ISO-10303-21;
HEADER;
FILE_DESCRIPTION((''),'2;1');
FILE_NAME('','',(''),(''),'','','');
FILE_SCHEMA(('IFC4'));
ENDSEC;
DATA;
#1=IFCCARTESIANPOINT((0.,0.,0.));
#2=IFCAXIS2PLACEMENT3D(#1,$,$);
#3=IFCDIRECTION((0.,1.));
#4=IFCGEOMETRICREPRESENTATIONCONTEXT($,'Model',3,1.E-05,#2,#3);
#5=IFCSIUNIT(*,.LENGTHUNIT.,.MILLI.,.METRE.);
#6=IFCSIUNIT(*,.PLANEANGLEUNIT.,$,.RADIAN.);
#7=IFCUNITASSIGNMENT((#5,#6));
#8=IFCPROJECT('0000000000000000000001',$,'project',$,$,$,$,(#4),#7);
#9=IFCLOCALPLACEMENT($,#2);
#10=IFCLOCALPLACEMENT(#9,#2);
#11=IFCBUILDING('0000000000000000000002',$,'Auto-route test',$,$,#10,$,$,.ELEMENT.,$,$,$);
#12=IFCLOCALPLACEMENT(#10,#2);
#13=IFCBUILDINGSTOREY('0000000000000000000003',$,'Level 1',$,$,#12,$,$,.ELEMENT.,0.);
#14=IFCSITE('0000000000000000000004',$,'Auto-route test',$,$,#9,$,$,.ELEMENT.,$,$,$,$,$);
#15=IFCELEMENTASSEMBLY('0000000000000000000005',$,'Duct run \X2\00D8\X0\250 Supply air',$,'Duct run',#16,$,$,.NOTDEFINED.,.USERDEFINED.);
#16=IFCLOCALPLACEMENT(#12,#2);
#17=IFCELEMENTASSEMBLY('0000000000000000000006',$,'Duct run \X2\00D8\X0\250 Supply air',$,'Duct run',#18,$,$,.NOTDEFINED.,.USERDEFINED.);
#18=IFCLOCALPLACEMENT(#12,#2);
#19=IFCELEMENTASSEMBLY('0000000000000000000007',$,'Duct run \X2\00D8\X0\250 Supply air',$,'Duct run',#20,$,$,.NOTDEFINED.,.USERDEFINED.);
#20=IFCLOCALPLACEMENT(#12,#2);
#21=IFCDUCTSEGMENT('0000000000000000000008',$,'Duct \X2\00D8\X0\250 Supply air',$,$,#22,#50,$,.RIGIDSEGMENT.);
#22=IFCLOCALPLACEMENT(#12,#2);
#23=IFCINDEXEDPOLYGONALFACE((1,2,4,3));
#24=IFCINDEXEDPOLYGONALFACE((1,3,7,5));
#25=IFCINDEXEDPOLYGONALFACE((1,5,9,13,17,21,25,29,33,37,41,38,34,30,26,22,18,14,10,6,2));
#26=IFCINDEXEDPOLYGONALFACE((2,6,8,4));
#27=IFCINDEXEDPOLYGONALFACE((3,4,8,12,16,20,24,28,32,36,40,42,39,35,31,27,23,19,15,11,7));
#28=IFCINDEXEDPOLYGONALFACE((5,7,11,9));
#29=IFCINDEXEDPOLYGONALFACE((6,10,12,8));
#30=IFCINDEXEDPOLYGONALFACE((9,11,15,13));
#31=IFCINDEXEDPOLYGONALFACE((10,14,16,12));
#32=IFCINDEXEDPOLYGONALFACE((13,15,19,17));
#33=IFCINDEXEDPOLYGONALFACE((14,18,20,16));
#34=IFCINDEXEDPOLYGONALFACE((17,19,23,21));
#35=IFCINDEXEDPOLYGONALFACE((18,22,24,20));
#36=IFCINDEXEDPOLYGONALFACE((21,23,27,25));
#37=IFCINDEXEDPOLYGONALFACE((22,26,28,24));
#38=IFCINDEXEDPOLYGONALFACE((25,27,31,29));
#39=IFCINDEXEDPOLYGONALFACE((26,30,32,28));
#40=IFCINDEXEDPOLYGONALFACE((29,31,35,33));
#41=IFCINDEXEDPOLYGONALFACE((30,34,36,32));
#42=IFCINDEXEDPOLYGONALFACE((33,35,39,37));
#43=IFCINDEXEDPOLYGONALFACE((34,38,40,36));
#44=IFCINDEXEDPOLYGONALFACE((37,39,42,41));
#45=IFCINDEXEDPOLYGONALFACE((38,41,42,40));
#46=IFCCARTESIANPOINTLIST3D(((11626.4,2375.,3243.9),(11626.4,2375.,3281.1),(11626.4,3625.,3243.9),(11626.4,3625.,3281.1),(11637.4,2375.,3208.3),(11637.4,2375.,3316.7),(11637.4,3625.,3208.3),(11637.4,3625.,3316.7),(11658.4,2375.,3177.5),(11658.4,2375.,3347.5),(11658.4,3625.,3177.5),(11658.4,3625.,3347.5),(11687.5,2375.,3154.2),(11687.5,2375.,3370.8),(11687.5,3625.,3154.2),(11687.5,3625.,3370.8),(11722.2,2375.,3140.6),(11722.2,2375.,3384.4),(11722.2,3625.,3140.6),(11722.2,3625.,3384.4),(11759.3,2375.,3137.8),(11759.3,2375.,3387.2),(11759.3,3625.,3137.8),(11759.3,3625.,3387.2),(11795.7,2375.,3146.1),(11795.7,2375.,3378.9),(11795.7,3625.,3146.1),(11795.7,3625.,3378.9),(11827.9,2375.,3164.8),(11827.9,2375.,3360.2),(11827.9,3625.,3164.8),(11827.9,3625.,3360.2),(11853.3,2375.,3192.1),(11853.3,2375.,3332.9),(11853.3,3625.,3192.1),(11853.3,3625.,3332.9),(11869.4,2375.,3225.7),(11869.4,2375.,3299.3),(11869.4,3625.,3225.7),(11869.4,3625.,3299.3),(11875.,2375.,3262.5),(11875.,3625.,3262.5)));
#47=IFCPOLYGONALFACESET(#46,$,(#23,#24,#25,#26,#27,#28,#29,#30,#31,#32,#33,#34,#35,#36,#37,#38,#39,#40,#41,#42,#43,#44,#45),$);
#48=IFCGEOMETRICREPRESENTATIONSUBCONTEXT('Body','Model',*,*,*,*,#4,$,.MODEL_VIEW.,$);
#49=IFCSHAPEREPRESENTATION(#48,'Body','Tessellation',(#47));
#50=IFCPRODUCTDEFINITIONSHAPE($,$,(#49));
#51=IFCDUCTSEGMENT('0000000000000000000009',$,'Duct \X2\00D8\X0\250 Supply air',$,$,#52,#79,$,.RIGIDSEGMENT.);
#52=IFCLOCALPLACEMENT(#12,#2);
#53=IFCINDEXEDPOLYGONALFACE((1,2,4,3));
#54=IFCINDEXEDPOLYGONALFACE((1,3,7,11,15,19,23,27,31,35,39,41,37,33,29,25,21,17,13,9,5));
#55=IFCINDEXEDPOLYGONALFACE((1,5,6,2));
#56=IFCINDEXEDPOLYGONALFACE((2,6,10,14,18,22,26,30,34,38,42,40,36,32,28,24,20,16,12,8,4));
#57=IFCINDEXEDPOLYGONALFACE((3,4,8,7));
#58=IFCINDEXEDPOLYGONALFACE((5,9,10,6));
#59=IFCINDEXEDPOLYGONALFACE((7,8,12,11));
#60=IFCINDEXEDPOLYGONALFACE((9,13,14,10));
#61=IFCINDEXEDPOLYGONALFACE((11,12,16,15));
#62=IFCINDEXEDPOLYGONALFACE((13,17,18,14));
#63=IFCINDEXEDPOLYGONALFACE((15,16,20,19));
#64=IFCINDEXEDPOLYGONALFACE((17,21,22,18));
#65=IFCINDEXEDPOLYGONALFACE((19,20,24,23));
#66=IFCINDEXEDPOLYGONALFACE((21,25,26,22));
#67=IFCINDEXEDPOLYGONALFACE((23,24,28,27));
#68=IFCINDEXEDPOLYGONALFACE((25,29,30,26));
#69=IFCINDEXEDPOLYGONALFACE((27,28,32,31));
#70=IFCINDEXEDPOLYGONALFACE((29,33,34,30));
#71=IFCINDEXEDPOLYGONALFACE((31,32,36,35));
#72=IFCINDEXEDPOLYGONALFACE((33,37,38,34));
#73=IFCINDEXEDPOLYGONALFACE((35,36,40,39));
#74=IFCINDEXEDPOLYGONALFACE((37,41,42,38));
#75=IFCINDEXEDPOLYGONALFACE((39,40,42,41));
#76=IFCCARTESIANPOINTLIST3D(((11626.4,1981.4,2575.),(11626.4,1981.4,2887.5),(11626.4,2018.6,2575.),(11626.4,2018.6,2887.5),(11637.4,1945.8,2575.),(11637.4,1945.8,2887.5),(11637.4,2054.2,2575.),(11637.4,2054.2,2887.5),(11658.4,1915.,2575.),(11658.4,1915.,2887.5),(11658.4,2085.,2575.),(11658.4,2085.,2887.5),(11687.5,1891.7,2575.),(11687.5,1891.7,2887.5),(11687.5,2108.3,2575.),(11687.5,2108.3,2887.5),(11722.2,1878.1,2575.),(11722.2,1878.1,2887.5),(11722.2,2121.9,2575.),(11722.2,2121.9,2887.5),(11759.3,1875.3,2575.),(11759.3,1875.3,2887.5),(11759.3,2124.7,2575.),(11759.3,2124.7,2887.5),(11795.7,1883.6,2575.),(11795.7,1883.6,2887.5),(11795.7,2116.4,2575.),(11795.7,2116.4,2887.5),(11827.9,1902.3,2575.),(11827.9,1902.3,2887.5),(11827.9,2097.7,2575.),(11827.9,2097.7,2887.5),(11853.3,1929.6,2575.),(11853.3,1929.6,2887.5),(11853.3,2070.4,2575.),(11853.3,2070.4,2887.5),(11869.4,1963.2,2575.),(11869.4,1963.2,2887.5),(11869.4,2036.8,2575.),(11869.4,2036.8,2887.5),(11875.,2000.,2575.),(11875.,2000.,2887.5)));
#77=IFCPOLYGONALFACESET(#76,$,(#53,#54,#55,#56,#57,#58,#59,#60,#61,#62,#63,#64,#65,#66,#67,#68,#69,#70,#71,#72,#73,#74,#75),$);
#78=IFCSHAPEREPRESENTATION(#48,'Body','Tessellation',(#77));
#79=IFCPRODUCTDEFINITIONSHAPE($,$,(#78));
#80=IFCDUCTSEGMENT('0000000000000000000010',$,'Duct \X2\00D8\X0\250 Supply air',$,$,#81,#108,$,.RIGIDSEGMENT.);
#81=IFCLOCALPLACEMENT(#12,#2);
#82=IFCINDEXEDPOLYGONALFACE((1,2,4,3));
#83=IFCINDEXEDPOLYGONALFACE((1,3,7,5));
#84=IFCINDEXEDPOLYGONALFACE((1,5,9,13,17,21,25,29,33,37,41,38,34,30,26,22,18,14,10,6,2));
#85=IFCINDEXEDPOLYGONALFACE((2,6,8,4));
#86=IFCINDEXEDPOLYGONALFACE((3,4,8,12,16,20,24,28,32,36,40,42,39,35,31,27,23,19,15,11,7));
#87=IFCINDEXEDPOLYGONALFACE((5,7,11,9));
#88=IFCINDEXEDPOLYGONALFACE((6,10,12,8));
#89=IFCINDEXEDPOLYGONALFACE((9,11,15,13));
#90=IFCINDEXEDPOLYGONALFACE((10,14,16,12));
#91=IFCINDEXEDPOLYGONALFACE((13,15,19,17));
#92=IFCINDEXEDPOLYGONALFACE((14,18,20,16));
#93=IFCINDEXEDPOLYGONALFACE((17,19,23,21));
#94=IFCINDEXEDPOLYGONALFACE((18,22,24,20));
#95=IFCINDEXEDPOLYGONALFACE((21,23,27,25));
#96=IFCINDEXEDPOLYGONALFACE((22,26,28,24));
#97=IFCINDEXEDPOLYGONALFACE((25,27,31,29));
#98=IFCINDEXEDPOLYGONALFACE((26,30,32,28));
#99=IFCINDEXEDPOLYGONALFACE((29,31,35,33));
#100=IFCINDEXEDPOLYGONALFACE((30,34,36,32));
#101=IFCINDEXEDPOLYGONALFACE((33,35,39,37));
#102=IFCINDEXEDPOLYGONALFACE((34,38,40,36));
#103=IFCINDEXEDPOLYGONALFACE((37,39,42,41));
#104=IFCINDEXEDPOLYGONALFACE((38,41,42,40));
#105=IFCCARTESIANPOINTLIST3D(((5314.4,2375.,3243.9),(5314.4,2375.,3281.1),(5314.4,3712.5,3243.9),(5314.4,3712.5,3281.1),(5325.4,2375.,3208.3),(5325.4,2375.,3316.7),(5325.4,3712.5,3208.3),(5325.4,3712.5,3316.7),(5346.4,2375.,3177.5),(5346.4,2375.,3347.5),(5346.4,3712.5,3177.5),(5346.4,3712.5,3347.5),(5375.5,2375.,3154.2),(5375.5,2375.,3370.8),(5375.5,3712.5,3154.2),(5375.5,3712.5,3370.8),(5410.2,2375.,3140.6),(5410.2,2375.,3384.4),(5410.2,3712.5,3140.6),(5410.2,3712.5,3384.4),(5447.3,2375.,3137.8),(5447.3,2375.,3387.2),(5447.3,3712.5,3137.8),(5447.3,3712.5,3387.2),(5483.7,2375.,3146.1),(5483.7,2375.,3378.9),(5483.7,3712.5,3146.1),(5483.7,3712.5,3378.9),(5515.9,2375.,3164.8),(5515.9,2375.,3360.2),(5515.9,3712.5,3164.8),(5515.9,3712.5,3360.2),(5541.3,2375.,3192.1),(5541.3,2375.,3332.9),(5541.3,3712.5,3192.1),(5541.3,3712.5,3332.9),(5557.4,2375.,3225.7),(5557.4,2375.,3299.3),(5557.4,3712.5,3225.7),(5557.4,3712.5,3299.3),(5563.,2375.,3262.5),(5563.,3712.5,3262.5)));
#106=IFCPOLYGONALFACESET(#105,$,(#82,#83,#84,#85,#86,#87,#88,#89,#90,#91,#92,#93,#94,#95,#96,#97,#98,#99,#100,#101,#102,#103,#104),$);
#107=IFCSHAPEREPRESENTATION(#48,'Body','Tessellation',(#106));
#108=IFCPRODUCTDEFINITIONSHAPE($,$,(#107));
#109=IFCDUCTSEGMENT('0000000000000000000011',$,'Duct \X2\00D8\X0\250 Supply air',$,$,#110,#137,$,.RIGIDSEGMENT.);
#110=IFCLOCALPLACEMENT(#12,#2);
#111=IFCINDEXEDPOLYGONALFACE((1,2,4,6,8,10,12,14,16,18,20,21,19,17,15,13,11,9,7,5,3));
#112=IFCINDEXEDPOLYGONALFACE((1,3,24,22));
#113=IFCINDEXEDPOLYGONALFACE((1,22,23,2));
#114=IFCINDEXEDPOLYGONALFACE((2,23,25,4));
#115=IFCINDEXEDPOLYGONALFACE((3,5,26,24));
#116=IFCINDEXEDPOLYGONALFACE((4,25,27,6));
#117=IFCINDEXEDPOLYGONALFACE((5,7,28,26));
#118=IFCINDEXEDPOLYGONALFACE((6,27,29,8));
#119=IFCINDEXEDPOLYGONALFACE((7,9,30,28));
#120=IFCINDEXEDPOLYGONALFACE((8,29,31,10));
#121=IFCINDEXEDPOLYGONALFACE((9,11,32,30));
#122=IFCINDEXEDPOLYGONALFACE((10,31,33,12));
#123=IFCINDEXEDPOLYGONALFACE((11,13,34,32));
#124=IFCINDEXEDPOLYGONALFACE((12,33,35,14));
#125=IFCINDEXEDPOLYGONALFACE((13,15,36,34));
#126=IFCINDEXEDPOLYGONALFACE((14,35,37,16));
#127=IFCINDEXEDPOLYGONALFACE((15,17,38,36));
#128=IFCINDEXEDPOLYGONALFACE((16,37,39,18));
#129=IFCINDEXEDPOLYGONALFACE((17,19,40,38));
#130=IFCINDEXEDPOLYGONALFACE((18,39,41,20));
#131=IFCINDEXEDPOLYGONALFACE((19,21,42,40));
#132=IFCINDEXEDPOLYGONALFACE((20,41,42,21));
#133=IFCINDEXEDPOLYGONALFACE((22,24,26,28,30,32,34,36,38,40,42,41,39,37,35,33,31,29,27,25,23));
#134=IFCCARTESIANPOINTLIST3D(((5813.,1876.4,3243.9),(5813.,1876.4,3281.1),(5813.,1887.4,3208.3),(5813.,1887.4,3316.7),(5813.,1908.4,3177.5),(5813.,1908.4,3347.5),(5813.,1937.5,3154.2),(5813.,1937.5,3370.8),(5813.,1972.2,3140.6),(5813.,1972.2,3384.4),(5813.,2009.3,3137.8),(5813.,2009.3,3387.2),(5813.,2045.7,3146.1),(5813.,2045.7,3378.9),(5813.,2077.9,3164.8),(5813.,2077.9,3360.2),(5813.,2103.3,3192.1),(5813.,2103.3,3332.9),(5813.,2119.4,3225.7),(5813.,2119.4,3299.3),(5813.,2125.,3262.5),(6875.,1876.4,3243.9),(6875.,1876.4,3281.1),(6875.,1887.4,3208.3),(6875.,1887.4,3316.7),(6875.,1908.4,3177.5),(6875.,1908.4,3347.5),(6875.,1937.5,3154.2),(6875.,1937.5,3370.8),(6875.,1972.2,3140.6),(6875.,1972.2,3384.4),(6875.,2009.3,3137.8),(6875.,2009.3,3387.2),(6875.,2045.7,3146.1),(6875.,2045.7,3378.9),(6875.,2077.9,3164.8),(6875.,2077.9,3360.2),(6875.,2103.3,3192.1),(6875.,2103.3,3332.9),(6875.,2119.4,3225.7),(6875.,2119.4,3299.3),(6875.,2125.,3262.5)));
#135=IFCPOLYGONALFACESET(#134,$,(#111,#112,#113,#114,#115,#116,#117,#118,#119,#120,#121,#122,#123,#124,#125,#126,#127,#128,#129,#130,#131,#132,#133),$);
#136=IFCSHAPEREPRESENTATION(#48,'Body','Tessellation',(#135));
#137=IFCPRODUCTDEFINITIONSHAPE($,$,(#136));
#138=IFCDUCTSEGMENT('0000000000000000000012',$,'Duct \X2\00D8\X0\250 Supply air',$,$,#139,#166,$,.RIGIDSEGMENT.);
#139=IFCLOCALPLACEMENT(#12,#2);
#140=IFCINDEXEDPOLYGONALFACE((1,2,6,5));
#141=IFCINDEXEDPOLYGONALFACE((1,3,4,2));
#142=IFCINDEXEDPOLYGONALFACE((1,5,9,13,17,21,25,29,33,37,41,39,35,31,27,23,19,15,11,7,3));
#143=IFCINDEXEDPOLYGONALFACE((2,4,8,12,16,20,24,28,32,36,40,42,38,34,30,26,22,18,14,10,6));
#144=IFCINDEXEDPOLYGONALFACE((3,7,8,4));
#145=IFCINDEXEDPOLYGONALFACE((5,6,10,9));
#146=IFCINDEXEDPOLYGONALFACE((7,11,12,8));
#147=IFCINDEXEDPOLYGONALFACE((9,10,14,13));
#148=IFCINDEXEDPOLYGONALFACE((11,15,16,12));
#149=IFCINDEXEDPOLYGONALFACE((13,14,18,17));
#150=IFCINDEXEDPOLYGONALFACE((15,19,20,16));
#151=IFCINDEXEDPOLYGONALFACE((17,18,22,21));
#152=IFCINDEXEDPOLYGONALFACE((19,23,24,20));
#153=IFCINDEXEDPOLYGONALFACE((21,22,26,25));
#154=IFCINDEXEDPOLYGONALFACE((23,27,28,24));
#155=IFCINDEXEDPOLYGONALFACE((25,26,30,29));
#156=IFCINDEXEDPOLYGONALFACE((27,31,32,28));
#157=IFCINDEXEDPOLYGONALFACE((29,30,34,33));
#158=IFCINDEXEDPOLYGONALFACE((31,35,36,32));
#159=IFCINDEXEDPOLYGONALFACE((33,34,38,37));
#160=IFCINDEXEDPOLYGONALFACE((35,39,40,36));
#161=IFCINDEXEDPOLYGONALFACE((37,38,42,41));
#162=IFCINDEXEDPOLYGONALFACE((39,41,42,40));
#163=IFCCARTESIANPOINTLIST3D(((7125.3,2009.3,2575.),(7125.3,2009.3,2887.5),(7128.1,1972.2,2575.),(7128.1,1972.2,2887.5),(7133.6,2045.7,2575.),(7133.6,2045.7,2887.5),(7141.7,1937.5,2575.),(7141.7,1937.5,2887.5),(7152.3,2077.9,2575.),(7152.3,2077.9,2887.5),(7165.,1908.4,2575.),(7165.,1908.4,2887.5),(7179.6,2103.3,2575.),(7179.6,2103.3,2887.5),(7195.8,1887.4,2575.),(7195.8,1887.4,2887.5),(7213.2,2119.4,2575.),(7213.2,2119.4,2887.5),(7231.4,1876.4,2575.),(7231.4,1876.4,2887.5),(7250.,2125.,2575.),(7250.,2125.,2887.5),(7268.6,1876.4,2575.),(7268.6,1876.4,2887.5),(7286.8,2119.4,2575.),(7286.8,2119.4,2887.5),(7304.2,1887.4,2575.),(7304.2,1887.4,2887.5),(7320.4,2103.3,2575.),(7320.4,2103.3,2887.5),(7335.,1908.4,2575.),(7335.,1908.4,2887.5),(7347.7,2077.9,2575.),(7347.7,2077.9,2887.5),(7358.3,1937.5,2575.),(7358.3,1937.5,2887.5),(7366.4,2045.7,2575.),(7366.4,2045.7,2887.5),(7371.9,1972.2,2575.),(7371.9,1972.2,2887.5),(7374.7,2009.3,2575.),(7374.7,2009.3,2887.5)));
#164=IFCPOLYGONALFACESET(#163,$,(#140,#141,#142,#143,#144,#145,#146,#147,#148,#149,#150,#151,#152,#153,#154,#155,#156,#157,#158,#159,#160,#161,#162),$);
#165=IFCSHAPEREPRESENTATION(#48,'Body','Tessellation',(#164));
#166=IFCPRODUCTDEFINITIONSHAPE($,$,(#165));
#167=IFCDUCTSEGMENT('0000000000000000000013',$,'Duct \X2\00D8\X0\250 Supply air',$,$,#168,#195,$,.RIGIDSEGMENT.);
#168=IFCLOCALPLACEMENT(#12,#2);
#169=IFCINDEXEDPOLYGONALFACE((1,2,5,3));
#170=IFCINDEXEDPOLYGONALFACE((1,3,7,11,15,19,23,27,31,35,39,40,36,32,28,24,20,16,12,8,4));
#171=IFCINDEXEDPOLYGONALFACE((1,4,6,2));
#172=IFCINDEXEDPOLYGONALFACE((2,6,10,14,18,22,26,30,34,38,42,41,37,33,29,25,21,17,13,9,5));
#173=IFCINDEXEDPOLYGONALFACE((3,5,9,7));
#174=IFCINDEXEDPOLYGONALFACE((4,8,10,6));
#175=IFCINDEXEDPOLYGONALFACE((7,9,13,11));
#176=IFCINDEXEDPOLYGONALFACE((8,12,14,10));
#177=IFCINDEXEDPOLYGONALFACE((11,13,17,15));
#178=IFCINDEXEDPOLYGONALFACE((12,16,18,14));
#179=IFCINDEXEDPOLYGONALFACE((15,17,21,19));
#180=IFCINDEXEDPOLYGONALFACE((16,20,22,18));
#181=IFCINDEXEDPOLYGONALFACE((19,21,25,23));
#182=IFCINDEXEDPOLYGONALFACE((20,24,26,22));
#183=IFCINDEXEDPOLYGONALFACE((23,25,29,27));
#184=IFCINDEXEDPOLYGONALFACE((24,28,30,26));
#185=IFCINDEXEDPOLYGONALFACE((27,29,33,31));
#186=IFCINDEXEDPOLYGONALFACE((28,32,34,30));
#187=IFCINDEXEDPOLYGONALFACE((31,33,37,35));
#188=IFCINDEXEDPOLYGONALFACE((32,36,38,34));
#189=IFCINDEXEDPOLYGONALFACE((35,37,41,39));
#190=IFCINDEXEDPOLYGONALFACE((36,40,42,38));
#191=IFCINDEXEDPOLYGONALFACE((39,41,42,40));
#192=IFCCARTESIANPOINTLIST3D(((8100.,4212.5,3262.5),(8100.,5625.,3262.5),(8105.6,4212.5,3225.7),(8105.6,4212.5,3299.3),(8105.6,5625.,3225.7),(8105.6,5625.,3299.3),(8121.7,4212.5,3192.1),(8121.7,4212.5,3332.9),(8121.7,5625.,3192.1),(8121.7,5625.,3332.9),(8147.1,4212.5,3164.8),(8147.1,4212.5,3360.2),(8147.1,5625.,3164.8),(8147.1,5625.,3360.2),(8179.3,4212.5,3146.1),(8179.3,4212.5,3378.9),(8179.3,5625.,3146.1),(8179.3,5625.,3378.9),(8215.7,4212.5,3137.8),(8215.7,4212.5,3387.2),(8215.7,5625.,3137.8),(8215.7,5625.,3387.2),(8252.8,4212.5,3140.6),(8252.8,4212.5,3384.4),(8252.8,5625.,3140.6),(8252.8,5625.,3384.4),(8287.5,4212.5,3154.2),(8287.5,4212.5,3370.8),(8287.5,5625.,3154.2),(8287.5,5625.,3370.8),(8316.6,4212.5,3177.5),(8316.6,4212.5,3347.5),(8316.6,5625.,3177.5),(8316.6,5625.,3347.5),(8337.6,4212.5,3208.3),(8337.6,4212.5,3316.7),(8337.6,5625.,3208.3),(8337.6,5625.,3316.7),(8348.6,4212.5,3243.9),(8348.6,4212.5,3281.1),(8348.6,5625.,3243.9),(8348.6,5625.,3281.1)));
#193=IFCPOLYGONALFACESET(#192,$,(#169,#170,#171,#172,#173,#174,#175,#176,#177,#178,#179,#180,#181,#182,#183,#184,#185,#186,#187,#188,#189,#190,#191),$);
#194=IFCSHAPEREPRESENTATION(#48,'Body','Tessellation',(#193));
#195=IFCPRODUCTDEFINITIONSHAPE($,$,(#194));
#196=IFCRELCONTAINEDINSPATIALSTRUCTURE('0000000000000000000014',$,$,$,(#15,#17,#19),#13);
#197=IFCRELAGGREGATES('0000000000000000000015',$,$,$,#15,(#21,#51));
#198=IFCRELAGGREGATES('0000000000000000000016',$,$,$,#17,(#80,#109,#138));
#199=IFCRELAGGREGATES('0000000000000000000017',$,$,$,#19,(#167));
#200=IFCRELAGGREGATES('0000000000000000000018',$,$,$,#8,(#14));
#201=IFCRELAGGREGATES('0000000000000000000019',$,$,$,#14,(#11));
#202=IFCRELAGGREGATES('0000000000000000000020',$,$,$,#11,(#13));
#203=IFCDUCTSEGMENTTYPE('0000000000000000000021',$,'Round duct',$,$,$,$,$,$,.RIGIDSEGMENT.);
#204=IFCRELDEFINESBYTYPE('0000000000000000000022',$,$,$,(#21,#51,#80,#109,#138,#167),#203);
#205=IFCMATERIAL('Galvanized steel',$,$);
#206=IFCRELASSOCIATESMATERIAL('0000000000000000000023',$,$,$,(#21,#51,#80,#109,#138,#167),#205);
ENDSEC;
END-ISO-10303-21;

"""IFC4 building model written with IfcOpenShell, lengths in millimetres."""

from ifc_helpers import new_model, si_unit, direction, frame, origin, origin_with_axes, origin_2d, place, context, subcontext, project, spatial, circle, extrude, material, type_object, element, aggregate, save


model = new_model("IFC4")

# Units and contexts
model_context = context("Model", 3, precision=1e-05, world=origin(), true_north=direction((0.0, 1.0)))
body_context = subcontext(model_context, "Body", "Model", "MODEL_VIEW")
ifc_project = project(units=[si_unit("LENGTHUNIT", "METRE", prefix="MILLI"), si_unit("PLANEANGLEUNIT", "RADIAN")], contexts=[model_context])

# Site, building, storey
site_placement = place(None, origin())
site = spatial("IfcSite", under=ifc_project, at=site_placement, Name="Auto-route test", CompositionType="ELEMENT")
building_placement = place(site_placement, origin())
building = spatial("IfcBuilding", under=site, at=building_placement, Name="Auto-route test", CompositionType="ELEMENT")
storey_placement = place(building_placement, origin())
storey = spatial("IfcBuildingStorey", under=building, at=storey_placement, Name="Level 1", CompositionType="ELEMENT", Elevation=0.0)

# Shared definitions
ifc_material_1 = material(Name="Galvanized steel")

# Element assembly
assembly_1_placement = place(storey_placement, origin_with_axes())
assembly_1 = element("IfcElementAssembly", 1, at=assembly_1_placement, inside=storey, Name="Duct run Ø250 Supply air", ObjectType="Duct run", AssemblyPlace="NOTDEFINED", PredefinedType="USERDEFINED")

# Element assemblies
assembly_2_placement = place(storey_placement, origin_with_axes())
assembly_2 = element("IfcElementAssembly", 2, at=assembly_2_placement, inside=storey, Name="Duct run Ø250 Supply air", ObjectType="Duct run", AssemblyPlace="NOTDEFINED", PredefinedType="USERDEFINED")
assembly_3_placement = place(storey_placement, origin_with_axes())
assembly_3 = element("IfcElementAssembly", 3, at=assembly_3_placement, inside=storey, Name="Duct run Ø250 Supply air", ObjectType="Duct run", AssemblyPlace="NOTDEFINED", PredefinedType="USERDEFINED")

# Duct segments
duct_segment_type_1 = type_object("IfcDuctSegmentType", Name="Round duct", PredefinedType="RIGIDSEGMENT")
duct_segment_1_placement = place(storey_placement, origin_with_axes())
duct_segment_1 = element("IfcDuctSegment", 4, at=duct_segment_1_placement, type_object=duct_segment_type_1, material=ifc_material_1, Name="Duct Ø250 Supply air", PredefinedType="RIGIDSEGMENT", context=body_context, shape_type="SweptSolid", body=[
    extrude(circle(Radius=125.0, at=origin_2d()), frame((11750.0, 3625.0, 3262.5), z_axis=(0.0, -1.0, 0.0), x_axis=(1.0, 0.0, 0.0)), (0.0, 0.0, 1.0), 1250.0),
])
duct_segment_2_placement = place(storey_placement, origin_with_axes())
duct_segment_2 = element("IfcDuctSegment", 5, at=duct_segment_2_placement, type_object=duct_segment_type_1, material=ifc_material_1, Name="Duct Ø250 Supply air", PredefinedType="RIGIDSEGMENT", context=body_context, shape_type="SweptSolid", body=[
    extrude(circle(Radius=125.0, at=origin_2d()), frame((11750.0, 2000.0, 2887.5), z_axis=(0.0, 0.0, -1.0), x_axis=(1.0, 0.0, 0.0)), (0.0, 0.0, 1.0), 312.5),
])
aggregate(assembly_1, [duct_segment_1, duct_segment_2])
duct_segment_3_placement = place(storey_placement, origin_with_axes())
duct_segment_3 = element("IfcDuctSegment", 6, at=duct_segment_3_placement, type_object=duct_segment_type_1, material=ifc_material_1, Name="Duct Ø250 Supply air", PredefinedType="RIGIDSEGMENT", context=body_context, shape_type="SweptSolid", body=[
    extrude(circle(Radius=125.0, at=origin_2d()), frame((5438.0, 3712.5, 3262.5), z_axis=(0.0, -1.0, 0.0), x_axis=(1.0, 0.0, 0.0)), (0.0, 0.0, 1.0), 1337.5),
])
duct_segment_4_placement = place(storey_placement, origin_with_axes())
duct_segment_4 = element("IfcDuctSegment", 7, at=duct_segment_4_placement, type_object=duct_segment_type_1, material=ifc_material_1, Name="Duct Ø250 Supply air", PredefinedType="RIGIDSEGMENT", context=body_context, shape_type="SweptSolid", body=[
    extrude(circle(Radius=125.0, at=origin_2d()), frame((5813.0, 2000.0, 3262.5), z_axis=(1.0, 0.0, 0.0), x_axis=(0.0, 1.0, 0.0)), (0.0, 0.0, 1.0), 1062.0),
])
duct_segment_5_placement = place(storey_placement, origin_with_axes())
duct_segment_5 = element("IfcDuctSegment", 8, at=duct_segment_5_placement, type_object=duct_segment_type_1, material=ifc_material_1, Name="Duct Ø250 Supply air", PredefinedType="RIGIDSEGMENT", context=body_context, shape_type="SweptSolid", body=[
    extrude(circle(Radius=125.0, at=origin_2d()), frame((7250.0, 2000.0, 2887.5), z_axis=(0.0, 0.0, -1.0), x_axis=(0.0, 1.0, 0.0)), (0.0, 0.0, 1.0), 312.5),
])
aggregate(assembly_2, [duct_segment_3, duct_segment_4, duct_segment_5])
duct_segment_6_placement = place(storey_placement, origin_with_axes())
duct_segment_6 = element("IfcDuctSegment", 9, at=duct_segment_6_placement, type_object=duct_segment_type_1, material=ifc_material_1, Name="Duct Ø250 Supply air", PredefinedType="RIGIDSEGMENT", context=body_context, shape_type="SweptSolid", body=[
    extrude(circle(Radius=125.0, at=origin_2d()), frame((8225.0, 4212.5, 3262.5), z_axis=(0.0, 1.0, 0.0), x_axis=(-1.0, 0.0, 0.0)), (0.0, 0.0, 1.0), 1412.5),
])
aggregate(assembly_3, [duct_segment_6])

save(model, "model.ifc")
